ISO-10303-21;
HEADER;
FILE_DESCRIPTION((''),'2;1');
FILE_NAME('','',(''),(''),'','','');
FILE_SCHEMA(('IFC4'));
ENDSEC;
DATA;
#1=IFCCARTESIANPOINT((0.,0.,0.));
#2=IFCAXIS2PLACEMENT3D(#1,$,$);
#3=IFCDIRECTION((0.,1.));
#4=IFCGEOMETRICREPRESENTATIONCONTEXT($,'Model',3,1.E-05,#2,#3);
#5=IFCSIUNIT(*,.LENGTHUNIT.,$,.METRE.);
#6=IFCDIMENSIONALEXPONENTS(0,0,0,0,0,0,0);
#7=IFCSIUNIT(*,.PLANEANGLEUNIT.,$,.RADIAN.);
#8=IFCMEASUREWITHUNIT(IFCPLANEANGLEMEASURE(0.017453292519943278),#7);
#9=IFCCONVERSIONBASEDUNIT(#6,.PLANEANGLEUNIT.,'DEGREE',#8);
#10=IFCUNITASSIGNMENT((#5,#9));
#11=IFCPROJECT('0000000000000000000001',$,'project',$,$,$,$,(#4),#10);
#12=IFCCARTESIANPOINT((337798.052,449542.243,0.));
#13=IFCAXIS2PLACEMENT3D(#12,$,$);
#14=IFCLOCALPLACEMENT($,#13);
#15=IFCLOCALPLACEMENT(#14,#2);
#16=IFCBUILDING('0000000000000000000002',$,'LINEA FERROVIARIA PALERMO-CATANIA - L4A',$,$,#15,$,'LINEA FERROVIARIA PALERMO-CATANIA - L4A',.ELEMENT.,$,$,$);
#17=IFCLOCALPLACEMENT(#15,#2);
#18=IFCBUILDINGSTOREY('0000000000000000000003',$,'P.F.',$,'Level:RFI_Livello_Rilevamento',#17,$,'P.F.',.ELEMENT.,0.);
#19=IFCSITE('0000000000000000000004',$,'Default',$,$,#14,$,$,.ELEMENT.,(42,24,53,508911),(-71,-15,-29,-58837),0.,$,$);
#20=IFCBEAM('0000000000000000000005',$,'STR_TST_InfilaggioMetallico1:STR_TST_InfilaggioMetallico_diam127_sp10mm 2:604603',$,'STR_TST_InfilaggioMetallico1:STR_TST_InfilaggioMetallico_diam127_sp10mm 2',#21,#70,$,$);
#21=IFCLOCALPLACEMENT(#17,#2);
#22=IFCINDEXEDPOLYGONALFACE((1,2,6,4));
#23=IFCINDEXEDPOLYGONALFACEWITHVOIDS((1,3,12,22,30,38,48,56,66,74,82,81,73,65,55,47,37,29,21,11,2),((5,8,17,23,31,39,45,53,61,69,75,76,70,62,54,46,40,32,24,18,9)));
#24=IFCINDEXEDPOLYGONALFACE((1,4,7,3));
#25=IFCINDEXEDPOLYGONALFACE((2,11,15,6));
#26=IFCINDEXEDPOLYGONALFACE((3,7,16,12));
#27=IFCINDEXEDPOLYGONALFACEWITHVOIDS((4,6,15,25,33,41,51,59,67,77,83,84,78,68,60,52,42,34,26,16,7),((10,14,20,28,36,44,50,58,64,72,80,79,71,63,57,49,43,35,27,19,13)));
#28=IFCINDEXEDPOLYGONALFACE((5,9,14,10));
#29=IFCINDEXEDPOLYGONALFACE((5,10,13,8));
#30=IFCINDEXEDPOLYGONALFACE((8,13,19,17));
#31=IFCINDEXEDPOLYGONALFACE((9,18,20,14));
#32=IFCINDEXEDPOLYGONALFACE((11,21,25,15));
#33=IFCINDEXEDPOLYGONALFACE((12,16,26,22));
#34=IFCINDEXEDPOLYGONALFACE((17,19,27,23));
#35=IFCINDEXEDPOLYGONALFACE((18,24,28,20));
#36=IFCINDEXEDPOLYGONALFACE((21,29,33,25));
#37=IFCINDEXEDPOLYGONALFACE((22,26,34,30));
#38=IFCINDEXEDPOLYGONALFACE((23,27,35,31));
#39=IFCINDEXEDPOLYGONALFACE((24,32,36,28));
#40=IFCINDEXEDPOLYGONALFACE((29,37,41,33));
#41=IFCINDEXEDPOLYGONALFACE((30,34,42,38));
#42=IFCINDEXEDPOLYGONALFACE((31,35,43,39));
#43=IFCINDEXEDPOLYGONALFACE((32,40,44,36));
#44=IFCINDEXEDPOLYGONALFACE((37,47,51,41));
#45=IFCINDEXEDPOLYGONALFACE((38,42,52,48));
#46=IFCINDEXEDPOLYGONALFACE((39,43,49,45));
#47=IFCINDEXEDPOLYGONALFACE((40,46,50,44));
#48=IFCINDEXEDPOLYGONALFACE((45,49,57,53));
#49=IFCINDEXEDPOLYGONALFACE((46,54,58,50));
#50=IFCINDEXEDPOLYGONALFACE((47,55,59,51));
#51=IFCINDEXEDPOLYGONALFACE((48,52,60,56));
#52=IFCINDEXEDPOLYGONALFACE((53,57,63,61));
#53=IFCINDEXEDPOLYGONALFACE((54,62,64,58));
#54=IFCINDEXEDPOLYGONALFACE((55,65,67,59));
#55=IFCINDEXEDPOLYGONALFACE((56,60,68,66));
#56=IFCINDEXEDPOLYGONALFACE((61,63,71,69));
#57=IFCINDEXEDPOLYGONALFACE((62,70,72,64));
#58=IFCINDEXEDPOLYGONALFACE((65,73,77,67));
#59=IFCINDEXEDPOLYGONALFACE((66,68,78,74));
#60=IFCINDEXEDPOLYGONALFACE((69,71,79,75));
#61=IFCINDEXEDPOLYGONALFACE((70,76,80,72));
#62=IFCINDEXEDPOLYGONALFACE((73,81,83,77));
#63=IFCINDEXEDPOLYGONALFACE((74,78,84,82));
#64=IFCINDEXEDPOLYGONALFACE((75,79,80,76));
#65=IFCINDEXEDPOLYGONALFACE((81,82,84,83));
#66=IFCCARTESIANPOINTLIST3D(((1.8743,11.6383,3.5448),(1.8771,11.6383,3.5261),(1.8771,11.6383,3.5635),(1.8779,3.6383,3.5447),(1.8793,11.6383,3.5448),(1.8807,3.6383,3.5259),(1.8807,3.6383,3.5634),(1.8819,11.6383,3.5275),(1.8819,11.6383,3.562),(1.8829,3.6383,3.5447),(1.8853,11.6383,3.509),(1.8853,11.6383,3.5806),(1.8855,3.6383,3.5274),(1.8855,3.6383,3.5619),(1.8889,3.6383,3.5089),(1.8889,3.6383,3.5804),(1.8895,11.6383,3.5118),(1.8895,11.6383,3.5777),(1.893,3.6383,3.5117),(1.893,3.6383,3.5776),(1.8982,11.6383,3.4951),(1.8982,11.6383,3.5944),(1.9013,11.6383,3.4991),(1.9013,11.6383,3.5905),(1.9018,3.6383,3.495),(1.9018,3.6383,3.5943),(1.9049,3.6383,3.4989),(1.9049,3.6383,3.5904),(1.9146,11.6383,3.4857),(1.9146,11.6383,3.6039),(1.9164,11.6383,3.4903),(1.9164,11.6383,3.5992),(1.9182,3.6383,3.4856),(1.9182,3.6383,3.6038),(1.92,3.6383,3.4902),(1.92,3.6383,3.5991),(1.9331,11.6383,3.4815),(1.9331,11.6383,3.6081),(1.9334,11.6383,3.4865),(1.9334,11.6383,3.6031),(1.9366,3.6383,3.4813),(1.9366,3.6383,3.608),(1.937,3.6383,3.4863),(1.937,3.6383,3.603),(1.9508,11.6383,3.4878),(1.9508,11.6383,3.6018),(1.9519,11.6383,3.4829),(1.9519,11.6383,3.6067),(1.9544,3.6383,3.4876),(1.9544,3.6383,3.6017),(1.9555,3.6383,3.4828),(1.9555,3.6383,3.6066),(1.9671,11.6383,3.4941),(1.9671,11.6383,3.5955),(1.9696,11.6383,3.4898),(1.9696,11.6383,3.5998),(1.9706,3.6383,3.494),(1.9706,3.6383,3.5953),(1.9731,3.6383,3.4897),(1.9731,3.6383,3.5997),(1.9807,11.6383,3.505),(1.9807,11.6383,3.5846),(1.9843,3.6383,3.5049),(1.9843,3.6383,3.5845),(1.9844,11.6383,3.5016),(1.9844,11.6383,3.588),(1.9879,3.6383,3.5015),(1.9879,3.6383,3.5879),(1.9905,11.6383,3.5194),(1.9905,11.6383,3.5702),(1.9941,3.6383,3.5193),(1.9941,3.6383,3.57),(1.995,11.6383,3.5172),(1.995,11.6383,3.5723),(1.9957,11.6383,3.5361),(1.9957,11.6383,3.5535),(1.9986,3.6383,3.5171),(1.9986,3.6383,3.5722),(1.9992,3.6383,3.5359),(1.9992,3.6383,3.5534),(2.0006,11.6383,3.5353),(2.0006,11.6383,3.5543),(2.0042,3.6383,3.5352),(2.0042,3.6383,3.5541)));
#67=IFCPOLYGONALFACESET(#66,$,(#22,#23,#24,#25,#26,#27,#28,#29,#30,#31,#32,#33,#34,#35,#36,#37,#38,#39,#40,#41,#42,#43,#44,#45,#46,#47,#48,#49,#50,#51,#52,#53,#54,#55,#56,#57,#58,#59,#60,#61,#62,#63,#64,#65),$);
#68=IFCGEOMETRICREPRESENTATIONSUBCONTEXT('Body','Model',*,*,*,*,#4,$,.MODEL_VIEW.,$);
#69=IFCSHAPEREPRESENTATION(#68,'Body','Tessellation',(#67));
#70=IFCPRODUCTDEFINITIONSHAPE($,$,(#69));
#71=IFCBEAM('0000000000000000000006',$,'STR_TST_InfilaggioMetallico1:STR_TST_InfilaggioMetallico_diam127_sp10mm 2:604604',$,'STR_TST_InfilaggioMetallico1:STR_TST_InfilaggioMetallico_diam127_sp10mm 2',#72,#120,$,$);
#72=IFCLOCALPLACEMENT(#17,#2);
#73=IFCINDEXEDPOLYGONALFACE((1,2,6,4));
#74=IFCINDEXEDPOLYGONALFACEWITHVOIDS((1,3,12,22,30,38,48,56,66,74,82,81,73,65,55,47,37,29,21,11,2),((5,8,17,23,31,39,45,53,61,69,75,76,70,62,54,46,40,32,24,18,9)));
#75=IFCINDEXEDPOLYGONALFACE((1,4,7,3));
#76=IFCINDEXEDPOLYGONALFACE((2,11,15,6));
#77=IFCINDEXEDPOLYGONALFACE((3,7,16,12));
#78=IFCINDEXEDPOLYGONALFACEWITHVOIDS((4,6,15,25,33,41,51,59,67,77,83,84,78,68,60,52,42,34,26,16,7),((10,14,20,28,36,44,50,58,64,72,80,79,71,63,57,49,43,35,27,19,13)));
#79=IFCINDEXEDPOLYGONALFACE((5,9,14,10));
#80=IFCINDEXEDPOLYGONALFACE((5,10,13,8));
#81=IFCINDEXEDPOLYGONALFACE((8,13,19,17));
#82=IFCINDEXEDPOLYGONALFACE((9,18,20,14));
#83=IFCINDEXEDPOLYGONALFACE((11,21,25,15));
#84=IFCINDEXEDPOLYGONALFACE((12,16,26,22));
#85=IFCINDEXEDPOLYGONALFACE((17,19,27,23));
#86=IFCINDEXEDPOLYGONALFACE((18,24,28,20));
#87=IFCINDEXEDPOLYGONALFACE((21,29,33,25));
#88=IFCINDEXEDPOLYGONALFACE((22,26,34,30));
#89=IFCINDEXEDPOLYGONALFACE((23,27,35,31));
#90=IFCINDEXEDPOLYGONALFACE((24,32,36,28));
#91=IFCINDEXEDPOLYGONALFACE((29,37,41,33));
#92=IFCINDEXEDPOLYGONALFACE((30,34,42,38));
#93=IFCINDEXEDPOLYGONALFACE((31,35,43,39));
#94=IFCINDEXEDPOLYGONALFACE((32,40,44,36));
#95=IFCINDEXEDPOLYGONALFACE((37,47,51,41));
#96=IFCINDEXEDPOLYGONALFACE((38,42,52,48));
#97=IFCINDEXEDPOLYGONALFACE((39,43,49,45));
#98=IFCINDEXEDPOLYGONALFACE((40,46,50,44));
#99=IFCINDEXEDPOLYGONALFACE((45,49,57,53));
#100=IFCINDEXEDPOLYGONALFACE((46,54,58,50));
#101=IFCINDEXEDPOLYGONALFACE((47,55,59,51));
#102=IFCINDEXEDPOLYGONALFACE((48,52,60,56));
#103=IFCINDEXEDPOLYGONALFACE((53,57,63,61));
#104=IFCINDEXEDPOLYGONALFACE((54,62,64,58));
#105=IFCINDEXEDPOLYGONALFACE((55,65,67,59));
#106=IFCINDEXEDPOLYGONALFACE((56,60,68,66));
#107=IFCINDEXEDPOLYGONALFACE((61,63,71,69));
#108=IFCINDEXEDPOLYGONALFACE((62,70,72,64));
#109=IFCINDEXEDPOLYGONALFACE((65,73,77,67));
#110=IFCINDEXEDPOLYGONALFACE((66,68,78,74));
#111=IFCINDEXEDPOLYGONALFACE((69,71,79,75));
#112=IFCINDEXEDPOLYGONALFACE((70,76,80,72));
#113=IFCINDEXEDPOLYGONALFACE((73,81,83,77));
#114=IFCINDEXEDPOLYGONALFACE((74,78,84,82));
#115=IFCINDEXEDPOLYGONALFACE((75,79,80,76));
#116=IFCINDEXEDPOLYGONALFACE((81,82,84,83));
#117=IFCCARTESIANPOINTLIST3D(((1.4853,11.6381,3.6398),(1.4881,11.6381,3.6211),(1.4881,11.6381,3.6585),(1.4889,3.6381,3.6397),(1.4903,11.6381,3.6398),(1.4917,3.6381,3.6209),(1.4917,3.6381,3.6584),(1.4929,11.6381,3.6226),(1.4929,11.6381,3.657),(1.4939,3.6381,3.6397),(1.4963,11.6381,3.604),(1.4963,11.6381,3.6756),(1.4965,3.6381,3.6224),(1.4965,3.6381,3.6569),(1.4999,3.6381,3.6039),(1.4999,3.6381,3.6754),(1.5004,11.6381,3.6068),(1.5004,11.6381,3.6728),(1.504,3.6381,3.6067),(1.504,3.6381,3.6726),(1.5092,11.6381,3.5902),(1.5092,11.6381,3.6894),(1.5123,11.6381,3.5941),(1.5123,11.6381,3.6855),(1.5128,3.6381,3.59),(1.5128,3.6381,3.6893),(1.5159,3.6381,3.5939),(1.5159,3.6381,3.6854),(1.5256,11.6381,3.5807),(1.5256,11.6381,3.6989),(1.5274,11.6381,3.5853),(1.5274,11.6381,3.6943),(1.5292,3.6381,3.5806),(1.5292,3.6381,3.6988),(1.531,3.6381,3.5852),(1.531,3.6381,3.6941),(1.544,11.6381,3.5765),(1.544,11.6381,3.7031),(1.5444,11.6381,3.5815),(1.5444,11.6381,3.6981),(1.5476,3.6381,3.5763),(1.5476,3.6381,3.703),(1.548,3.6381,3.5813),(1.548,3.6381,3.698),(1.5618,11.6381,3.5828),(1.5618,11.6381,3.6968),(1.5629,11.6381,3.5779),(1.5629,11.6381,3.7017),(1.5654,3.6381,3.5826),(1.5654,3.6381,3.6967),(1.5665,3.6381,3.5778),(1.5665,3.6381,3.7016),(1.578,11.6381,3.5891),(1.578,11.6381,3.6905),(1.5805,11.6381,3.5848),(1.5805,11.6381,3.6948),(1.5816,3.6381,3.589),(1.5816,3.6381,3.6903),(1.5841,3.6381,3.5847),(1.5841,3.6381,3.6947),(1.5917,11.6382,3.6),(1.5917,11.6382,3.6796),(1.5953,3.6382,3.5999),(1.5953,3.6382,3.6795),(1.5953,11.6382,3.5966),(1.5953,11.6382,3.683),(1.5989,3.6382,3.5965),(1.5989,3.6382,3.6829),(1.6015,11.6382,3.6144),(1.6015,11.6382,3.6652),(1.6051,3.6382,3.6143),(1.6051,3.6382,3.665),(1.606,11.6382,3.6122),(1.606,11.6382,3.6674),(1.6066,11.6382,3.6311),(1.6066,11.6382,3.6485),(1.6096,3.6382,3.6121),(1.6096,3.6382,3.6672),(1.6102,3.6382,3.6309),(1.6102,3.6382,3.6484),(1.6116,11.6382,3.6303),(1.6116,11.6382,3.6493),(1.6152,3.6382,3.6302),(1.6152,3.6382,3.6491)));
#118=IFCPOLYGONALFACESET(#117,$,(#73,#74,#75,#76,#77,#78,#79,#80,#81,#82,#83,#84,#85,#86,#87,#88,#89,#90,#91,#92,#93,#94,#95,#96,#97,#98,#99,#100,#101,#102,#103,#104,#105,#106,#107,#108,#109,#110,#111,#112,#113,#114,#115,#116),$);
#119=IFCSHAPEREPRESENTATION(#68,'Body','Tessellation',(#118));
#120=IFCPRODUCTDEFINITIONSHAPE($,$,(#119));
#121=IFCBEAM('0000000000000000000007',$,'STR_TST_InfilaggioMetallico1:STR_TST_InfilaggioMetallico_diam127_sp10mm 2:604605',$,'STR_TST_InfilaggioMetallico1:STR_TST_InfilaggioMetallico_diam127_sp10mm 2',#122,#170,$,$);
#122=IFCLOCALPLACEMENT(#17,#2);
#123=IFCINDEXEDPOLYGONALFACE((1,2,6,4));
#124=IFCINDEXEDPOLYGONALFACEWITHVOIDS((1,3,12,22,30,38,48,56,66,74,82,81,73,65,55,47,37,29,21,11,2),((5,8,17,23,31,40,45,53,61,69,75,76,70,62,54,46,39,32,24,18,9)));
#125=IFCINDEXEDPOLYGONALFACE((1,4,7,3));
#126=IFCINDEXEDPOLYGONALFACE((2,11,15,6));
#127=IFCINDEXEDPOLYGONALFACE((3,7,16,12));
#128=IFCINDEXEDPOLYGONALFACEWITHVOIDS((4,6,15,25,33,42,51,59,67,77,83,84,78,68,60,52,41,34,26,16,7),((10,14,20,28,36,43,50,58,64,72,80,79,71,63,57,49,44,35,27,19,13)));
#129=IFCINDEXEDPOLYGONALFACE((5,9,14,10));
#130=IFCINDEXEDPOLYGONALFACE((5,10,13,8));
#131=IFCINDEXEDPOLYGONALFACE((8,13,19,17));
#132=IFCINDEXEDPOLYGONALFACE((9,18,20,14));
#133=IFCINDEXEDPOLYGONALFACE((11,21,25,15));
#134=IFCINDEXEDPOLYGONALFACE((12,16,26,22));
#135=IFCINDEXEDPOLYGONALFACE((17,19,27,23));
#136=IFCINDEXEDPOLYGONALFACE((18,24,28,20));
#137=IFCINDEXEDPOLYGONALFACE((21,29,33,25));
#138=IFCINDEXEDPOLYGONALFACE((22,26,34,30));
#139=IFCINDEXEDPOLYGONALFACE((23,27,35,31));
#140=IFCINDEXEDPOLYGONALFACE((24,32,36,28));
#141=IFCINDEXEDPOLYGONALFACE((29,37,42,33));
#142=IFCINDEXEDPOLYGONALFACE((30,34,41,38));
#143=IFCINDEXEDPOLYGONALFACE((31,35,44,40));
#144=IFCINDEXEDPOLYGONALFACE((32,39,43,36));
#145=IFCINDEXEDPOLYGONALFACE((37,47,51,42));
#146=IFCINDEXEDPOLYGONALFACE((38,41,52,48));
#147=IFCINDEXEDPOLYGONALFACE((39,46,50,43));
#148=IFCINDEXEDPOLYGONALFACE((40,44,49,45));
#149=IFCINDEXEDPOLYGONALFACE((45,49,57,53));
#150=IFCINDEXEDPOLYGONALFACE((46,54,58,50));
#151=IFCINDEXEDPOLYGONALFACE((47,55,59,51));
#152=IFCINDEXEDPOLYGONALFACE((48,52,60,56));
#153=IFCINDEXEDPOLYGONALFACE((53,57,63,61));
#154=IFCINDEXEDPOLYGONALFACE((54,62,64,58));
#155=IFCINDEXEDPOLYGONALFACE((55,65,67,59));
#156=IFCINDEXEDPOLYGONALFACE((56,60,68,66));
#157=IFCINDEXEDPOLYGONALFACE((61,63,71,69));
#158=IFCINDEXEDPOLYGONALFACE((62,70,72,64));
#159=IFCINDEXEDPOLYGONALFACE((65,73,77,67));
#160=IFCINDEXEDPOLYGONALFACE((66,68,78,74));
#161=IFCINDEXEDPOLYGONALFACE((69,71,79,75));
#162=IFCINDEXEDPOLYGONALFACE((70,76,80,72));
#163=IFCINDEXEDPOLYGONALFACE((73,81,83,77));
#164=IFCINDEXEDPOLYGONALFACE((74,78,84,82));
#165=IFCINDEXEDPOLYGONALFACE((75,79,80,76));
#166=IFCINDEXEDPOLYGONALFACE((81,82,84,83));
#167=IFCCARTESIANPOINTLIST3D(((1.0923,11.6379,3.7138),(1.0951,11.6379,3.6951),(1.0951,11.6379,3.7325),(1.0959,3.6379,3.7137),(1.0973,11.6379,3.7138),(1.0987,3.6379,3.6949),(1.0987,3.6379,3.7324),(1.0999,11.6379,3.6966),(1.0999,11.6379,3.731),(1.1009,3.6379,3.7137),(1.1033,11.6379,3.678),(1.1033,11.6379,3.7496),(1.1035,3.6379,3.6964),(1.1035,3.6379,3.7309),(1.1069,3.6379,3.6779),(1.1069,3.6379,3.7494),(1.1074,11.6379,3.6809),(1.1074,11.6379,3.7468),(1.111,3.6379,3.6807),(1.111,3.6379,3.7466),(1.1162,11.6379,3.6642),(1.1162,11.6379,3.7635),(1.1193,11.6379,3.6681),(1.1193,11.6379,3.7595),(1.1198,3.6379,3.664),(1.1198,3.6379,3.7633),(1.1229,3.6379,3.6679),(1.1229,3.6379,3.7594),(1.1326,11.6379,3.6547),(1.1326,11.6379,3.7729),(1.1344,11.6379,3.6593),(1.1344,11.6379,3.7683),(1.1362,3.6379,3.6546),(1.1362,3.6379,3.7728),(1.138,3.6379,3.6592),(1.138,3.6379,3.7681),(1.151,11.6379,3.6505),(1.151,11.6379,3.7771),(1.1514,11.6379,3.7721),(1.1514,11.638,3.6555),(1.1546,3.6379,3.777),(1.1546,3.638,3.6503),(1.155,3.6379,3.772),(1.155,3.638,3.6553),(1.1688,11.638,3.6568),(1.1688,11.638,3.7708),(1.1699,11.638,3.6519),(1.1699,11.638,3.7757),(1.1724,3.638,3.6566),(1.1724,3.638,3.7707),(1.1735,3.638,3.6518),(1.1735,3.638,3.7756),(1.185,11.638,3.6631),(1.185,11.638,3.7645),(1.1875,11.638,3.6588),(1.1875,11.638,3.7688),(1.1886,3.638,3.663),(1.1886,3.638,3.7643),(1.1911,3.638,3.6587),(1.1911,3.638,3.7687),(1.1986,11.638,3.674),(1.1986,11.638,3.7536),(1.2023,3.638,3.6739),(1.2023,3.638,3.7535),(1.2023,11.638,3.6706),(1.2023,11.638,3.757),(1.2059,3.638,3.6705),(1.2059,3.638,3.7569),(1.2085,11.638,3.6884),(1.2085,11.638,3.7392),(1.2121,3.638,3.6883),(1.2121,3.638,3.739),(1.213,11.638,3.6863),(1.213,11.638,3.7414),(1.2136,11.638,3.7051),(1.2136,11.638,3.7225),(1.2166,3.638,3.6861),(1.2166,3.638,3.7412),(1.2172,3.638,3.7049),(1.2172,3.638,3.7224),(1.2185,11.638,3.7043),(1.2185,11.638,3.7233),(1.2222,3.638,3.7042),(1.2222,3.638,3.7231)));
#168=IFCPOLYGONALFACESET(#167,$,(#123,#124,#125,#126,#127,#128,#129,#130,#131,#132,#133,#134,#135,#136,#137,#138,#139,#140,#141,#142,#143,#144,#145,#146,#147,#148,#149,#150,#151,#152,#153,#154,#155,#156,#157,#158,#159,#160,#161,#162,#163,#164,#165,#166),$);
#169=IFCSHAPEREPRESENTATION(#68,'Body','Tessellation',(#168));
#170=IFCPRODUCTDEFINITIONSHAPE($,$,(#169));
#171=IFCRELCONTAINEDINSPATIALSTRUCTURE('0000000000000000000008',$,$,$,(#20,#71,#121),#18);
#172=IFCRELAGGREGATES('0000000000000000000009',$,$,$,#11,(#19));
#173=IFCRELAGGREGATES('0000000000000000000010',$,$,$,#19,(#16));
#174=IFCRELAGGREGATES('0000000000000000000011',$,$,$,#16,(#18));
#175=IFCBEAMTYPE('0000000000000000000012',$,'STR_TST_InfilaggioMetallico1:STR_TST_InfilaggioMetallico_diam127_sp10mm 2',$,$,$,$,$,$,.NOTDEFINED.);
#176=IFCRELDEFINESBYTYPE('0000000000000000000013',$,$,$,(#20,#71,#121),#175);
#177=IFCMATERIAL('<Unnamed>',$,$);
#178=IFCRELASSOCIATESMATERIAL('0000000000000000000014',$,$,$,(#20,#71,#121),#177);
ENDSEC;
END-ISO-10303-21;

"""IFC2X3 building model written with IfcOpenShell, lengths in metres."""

from ifc_helpers import new_model, entity, si_unit, converted_unit, direction, frame, origin, origin_2d_with_axis, place, context, subcontext, project, spatial, hollow_circle, extrude, material, type_object, element, save


model = new_model("IFC2X3")

# Units and contexts
model_context = context("Model", 3, precision=1e-05, world=origin(), true_north=direction((0.0, 1.0)))
body_context = subcontext(model_context, "Body", "Model", "MODEL_VIEW")
ifc_project = project(units=[si_unit("LENGTHUNIT", "METRE"), converted_unit("PLANEANGLEUNIT", "DEGREE", entity("IfcPlaneAngleMeasure", 0.017453292519943278), si_unit("PLANEANGLEUNIT", "RADIAN"), dimensions=[0, 0, 0, 0, 0, 0, 0])], contexts=[model_context])

# Site, building, storey
site_placement = place(None, frame((337798.052, 449542.243, 0.0)))
site = spatial("IfcSite", under=ifc_project, at=site_placement, Name="Default", CompositionType="ELEMENT", RefLatitude=(42, 24, 53, 508911), RefLongitude=(-71, -15, -29, -58837), RefElevation=0.0)
building_placement = place(site_placement, origin())
building = spatial("IfcBuilding", under=site, at=building_placement, Name="LINEA FERROVIARIA PALERMO-CATANIA - L4A", LongName="LINEA FERROVIARIA PALERMO-CATANIA - L4A", CompositionType="ELEMENT")
storey_placement = place(building_placement, origin())
storey = spatial("IfcBuildingStorey", under=building, at=storey_placement, Name="P.F.", ObjectType="Level:RFI_Livello_Rilevamento", LongName="P.F.", CompositionType="ELEMENT", Elevation=0.0)

# Beams
ifc_material = material(Name="<Unnamed>")
beam_type = type_object("IfcBeamType", Name="STR_TST_InfilaggioMetallico1:STR_TST_InfilaggioMetallico_diam127_sp10mm 2", PredefinedType="NOTDEFINED")
beam_1_placement = place(storey_placement, frame((1.8727, 3.6383, 3.6099), z_axis=(0.0, -0.000016, 1.0), x_axis=(-0.000446, 1.0, 0.000016)))
element("IfcBeam", 1, at=beam_1_placement, inside=storey, type_object=beam_type, material=ifc_material, Name="STR_TST_InfilaggioMetallico1:STR_TST_InfilaggioMetallico_diam127_sp10mm 2:604603", ObjectType="STR_TST_InfilaggioMetallico1:STR_TST_InfilaggioMetallico_diam127_sp10mm 2", context=body_context, shape_type="SweptSolid", body=[
    extrude(hollow_circle(Radius=0.0635, WallThickness=0.005, at=origin_2d_with_axis()), frame((0.0, -0.0687, -0.0652), z_axis=(1.0, 0.0, 0.0), x_axis=(0.0, 1.0, 0.0)), (0.0, 0.0, 1.0), 8.0),
])
beam_2_placement = place(storey_placement, frame((1.4837, 3.6381, 3.7049), z_axis=(0.0, -0.000017, 1.0), x_axis=(-0.000449, 1.0, 0.000017)))
element("IfcBeam", 2, at=beam_2_placement, inside=storey, type_object=beam_type, material=ifc_material, Name="STR_TST_InfilaggioMetallico1:STR_TST_InfilaggioMetallico_diam127_sp10mm 2:604604", ObjectType="STR_TST_InfilaggioMetallico1:STR_TST_InfilaggioMetallico_diam127_sp10mm 2", context=body_context, shape_type="SweptSolid", body=[
    extrude(hollow_circle(Radius=0.0635, WallThickness=0.005, at=origin_2d_with_axis()), frame((0.0, -0.0687, -0.0652), z_axis=(1.0, 0.0, 0.0), x_axis=(0.0, 1.0, 0.0)), (0.0, 0.0, 1.0), 8.0),
])
beam_3_placement = place(storey_placement, frame((1.0907, 3.6379, 3.7789), z_axis=(0.0, -0.000018, 1.0), x_axis=(-0.000453, 1.0, 0.000018)))
element("IfcBeam", 3, at=beam_3_placement, inside=storey, type_object=beam_type, material=ifc_material, Name="STR_TST_InfilaggioMetallico1:STR_TST_InfilaggioMetallico_diam127_sp10mm 2:604605", ObjectType="STR_TST_InfilaggioMetallico1:STR_TST_InfilaggioMetallico_diam127_sp10mm 2", context=body_context, shape_type="SweptSolid", body=[
    extrude(hollow_circle(Radius=0.0635, WallThickness=0.005, at=origin_2d_with_axis()), frame((0.0, -0.0687, -0.0652), z_axis=(1.0, 0.0, 0.0), x_axis=(0.0, 1.0, 0.0)), (0.0, 0.0, 1.0), 8.0),
])

save(model, "model.ifc")
